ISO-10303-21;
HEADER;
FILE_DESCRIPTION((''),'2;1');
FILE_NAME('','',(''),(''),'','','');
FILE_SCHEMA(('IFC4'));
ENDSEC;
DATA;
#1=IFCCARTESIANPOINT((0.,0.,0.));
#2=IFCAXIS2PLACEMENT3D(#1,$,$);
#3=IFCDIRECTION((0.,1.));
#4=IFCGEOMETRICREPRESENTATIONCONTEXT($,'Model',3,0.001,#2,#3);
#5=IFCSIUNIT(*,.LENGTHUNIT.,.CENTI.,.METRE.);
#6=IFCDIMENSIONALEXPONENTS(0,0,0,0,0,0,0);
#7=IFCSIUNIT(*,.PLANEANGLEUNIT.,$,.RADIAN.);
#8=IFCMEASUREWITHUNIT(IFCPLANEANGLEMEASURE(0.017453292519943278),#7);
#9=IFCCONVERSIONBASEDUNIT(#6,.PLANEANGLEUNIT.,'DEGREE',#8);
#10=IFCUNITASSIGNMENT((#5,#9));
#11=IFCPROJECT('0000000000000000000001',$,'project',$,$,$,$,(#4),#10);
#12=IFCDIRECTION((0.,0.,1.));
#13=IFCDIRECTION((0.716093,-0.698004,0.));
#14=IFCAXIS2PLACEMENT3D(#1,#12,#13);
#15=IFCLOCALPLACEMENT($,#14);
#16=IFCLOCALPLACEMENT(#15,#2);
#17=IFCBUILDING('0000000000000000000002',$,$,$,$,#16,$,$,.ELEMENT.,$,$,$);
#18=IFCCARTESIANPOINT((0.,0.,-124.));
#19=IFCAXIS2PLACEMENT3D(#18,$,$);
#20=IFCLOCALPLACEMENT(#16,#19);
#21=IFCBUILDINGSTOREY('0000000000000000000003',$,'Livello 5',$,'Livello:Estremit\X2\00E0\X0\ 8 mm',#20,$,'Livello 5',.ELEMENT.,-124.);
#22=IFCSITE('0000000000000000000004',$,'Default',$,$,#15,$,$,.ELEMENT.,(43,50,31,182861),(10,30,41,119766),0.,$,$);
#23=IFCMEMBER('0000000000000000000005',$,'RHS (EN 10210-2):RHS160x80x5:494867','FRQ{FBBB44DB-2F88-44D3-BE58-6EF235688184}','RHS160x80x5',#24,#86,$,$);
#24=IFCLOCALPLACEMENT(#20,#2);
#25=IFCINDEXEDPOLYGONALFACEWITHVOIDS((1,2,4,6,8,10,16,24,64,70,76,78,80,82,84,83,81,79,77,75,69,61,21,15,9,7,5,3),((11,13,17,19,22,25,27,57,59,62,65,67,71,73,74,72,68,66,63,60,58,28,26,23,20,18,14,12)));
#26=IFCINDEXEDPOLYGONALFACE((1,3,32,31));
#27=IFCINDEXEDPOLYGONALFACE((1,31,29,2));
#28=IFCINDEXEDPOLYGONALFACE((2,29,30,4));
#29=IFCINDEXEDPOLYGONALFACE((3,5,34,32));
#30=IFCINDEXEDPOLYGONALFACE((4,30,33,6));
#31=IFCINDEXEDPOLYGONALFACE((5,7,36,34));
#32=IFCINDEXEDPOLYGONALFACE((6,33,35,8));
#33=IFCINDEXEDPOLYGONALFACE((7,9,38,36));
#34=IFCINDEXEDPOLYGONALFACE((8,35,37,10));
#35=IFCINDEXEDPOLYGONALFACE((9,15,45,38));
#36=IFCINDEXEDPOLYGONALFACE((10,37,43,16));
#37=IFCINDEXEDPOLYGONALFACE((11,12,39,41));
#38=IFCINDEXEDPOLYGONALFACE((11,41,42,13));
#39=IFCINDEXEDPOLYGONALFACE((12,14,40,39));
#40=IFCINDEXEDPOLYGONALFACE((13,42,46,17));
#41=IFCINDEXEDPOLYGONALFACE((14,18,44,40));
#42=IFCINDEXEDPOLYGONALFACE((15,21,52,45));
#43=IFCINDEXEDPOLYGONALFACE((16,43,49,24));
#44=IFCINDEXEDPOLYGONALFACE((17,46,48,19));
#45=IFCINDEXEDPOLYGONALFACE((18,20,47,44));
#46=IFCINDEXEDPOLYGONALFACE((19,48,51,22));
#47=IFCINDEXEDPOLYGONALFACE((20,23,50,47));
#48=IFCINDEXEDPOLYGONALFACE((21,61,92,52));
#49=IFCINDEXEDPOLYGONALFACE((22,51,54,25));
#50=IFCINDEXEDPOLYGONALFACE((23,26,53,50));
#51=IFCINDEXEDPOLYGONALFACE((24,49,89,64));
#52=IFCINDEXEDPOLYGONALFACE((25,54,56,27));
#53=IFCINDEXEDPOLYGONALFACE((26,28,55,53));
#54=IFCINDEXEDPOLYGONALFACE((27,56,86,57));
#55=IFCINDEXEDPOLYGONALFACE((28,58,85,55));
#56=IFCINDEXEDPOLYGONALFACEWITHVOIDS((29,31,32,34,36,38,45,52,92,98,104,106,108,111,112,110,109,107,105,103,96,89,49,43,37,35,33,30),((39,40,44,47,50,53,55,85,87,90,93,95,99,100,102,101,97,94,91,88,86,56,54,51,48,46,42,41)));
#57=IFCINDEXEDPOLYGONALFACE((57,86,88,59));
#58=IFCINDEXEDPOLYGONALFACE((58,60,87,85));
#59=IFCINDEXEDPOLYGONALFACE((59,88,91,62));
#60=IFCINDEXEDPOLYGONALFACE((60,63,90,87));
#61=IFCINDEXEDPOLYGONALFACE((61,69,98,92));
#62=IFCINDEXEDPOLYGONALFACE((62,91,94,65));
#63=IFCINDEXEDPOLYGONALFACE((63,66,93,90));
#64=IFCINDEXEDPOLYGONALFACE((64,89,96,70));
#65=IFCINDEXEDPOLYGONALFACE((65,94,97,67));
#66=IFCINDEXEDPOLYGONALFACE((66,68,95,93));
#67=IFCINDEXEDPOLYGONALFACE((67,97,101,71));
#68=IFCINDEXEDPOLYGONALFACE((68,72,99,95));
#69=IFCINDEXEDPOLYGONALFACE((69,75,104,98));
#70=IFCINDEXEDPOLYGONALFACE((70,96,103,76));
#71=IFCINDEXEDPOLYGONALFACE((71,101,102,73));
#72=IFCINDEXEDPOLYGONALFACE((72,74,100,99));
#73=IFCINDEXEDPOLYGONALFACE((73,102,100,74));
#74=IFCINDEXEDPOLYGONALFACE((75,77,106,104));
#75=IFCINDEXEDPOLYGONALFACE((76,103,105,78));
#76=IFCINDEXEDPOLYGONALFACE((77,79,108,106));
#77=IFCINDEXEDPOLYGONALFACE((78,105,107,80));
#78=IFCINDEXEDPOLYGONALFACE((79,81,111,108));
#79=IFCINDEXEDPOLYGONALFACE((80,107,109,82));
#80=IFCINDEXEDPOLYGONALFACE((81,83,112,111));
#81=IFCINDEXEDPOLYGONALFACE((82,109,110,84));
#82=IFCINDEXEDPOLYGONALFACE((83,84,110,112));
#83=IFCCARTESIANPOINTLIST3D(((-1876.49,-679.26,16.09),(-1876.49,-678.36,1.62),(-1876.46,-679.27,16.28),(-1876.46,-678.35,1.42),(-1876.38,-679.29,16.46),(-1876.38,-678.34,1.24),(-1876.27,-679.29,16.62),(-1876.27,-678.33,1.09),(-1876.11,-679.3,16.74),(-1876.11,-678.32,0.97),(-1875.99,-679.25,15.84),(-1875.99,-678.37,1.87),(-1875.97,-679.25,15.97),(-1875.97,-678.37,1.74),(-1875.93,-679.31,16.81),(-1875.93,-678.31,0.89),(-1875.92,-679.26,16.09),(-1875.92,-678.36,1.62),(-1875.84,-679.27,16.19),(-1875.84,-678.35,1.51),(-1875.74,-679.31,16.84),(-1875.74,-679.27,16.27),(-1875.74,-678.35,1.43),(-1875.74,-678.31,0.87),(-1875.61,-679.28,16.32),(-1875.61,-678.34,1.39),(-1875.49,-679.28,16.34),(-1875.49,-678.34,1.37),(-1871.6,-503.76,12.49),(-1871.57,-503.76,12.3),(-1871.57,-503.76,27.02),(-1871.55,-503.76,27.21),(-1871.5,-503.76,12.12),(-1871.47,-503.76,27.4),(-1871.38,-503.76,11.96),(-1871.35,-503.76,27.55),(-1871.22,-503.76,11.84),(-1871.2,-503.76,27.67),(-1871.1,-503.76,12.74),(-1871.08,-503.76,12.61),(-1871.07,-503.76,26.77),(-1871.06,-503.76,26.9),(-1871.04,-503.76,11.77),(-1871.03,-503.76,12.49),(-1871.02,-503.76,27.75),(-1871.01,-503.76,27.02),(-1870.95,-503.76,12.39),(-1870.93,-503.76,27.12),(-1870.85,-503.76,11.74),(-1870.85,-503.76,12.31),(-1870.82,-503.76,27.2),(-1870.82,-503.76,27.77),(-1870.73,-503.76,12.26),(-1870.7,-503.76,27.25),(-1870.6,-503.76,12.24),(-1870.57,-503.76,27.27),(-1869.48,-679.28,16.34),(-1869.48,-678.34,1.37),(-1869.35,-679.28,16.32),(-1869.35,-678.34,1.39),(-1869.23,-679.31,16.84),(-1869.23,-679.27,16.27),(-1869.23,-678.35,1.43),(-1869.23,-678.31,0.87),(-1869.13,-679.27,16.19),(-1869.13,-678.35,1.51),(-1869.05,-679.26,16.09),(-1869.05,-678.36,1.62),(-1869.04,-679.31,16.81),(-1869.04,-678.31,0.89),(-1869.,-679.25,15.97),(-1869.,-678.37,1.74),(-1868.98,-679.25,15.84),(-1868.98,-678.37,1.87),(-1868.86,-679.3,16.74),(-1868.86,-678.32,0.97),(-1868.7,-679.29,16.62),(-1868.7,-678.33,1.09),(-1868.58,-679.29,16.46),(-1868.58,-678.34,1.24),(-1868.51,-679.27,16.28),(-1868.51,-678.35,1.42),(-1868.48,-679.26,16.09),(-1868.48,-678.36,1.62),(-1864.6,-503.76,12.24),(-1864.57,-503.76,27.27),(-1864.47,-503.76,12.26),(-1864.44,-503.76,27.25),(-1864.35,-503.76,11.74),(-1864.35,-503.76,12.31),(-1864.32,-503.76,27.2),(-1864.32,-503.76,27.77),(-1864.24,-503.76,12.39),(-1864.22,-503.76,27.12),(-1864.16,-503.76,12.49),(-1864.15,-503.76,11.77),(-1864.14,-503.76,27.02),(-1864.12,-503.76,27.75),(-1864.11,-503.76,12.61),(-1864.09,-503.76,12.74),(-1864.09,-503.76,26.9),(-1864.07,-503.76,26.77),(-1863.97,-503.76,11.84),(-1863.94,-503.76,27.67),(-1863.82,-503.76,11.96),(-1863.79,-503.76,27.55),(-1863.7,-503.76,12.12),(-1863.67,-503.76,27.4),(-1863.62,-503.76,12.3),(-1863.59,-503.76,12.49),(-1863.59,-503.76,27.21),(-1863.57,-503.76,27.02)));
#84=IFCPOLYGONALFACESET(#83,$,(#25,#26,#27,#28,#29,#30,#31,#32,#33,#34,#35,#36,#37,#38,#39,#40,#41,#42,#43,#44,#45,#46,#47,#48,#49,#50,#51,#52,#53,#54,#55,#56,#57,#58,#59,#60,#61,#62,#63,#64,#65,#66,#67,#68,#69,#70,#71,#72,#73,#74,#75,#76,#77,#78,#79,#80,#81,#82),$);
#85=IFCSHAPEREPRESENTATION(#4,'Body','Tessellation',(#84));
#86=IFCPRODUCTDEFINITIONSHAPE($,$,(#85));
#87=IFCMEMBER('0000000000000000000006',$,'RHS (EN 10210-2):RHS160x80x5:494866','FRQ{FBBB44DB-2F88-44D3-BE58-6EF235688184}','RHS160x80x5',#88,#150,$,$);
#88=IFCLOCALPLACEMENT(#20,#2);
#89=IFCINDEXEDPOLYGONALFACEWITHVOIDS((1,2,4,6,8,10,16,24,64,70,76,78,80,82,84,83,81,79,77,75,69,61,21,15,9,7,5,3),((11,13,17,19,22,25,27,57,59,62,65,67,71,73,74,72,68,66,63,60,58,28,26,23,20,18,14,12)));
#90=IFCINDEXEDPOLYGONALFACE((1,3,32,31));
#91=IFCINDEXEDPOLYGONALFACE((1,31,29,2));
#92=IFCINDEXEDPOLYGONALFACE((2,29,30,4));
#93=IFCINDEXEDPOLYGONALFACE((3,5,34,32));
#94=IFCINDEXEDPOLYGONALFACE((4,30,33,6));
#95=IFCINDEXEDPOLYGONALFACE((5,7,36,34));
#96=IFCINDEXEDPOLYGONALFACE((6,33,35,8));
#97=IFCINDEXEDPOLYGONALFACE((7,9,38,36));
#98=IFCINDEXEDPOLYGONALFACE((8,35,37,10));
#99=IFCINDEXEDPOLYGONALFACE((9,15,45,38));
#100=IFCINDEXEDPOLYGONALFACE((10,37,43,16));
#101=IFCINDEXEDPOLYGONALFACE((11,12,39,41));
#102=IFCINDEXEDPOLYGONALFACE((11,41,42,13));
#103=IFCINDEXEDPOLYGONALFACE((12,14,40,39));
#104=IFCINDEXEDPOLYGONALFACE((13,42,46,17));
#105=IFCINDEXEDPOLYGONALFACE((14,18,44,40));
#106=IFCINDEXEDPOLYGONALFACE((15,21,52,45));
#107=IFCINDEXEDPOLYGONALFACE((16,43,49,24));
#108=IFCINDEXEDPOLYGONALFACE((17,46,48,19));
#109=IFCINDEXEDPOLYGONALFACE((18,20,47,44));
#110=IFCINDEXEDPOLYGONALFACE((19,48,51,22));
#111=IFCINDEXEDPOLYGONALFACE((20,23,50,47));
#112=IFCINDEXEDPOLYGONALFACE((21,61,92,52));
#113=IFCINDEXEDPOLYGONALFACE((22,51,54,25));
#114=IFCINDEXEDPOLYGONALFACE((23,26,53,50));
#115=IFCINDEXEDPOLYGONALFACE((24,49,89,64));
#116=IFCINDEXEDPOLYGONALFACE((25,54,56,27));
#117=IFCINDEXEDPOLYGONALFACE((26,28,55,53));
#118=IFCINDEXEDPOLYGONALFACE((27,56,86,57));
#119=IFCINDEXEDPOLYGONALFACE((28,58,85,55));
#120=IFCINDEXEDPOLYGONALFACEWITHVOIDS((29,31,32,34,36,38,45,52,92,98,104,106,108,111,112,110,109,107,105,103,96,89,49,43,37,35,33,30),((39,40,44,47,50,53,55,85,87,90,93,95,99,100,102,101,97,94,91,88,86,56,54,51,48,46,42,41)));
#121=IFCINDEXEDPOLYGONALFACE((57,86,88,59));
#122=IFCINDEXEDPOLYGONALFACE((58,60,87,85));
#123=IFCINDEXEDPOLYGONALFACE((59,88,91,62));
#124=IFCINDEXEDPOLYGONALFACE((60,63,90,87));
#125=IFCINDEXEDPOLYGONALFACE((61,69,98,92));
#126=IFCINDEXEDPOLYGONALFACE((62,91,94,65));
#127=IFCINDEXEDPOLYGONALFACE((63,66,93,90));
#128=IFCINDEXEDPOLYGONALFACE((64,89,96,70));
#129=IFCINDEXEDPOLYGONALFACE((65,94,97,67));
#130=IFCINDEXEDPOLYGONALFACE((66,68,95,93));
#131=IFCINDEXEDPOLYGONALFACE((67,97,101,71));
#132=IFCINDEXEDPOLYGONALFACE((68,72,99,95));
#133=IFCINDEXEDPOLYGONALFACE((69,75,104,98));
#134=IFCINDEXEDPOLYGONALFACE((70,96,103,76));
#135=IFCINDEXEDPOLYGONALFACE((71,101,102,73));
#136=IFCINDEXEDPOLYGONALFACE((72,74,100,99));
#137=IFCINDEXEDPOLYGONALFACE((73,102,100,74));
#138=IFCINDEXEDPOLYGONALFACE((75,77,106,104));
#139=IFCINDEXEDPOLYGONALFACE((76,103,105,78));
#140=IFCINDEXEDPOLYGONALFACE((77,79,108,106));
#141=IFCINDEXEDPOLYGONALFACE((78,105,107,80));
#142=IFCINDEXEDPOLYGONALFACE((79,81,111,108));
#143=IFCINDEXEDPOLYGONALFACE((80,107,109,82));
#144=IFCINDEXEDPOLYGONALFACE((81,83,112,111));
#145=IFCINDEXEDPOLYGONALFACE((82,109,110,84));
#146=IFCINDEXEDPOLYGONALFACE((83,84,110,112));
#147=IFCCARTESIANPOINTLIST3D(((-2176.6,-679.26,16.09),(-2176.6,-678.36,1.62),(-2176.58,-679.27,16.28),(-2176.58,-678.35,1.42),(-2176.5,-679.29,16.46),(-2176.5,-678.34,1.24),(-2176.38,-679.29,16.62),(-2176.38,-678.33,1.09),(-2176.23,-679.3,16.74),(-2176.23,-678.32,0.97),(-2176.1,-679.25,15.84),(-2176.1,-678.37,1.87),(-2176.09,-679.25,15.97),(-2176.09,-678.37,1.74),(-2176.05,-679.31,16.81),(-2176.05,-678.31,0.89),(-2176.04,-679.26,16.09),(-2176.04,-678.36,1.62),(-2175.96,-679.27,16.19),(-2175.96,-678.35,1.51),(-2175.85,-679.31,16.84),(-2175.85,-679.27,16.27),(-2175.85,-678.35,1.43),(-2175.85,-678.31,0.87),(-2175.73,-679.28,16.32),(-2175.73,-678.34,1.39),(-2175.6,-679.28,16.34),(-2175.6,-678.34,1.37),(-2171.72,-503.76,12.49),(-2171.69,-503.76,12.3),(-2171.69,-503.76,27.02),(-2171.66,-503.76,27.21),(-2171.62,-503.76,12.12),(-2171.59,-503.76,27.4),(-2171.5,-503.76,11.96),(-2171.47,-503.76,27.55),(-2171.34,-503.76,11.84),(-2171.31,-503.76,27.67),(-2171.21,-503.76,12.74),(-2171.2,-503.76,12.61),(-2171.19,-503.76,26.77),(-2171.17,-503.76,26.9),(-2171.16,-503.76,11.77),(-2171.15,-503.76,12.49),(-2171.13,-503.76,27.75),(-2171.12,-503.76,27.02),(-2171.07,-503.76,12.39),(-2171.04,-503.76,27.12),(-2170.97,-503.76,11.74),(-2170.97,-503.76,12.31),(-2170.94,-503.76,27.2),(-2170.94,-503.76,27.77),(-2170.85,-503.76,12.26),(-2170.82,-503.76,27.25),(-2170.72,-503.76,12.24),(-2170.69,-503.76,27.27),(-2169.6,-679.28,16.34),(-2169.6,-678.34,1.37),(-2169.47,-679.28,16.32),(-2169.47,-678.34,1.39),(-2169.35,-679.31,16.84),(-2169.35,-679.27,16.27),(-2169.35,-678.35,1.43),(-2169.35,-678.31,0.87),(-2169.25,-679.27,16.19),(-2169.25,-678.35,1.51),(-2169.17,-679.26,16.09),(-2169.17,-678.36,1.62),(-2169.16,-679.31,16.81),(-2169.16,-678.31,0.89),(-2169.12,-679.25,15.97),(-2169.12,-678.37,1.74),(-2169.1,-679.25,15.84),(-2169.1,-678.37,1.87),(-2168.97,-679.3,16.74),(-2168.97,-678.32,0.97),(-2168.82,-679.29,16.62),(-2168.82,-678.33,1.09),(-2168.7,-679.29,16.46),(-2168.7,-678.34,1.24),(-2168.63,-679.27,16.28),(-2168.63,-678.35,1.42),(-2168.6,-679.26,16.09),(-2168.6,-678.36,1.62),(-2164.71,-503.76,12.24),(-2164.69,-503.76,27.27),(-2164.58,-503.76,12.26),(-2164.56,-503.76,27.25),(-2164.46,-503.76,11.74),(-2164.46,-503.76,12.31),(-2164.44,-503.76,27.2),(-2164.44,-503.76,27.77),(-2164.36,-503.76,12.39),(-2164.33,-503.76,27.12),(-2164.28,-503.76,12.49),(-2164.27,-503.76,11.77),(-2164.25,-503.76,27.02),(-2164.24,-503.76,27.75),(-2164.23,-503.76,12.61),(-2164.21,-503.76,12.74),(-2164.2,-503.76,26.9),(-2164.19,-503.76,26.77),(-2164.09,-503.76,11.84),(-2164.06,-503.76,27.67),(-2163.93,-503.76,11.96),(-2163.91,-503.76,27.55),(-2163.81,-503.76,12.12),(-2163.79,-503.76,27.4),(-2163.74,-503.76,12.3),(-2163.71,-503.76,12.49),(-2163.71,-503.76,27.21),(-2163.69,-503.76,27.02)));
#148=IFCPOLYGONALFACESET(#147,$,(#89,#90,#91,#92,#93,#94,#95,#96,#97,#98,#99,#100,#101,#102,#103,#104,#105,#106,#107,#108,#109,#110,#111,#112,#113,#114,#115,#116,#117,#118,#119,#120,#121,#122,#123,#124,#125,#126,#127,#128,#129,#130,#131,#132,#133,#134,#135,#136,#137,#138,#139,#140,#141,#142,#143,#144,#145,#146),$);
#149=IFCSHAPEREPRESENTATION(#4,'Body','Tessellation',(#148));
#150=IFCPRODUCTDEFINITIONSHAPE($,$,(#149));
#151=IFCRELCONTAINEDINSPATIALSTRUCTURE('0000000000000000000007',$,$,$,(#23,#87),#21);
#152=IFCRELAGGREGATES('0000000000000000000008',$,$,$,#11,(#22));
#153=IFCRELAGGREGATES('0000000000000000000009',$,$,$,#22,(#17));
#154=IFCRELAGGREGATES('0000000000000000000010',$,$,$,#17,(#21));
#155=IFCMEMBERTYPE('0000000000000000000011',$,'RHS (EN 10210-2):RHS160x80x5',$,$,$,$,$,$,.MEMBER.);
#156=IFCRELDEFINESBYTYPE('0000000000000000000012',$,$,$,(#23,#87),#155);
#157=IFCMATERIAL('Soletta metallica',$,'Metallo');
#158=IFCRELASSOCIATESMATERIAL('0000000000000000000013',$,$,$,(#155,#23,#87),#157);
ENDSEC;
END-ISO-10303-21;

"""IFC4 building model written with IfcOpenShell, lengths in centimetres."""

from ifc_helpers import new_model, entity, si_unit, converted_unit, direction, frame, origin, origin_2d, place, context, project, spatial, hollow_rectangle, extrude, clip, halfspace, material, type_object, element, save


model = new_model("IFC4")

# Units and contexts
model_context = context("Model", 3, precision=0.001, world=origin(), true_north=direction((0.0, 1.0)))
ifc_project = project(units=[si_unit("LENGTHUNIT", "METRE", prefix="CENTI"), converted_unit("PLANEANGLEUNIT", "DEGREE", entity("IfcPlaneAngleMeasure", 0.017453292519943278), si_unit("PLANEANGLEUNIT", "RADIAN"), dimensions=[0, 0, 0, 0, 0, 0, 0])], contexts=[model_context])

# Site, building, storey
site_placement = place(None, frame((0.0, 0.0, 0.0), z_axis=(0.0, 0.0, 1.0), x_axis=(0.716093, -0.698004, 0.0)))
site = spatial("IfcSite", under=ifc_project, at=site_placement, Name="Default", CompositionType="ELEMENT", RefLatitude=(43, 50, 31, 182861), RefLongitude=(10, 30, 41, 119766), RefElevation=0.0)
building_placement = place(site_placement, origin())
building = spatial("IfcBuilding", under=site, at=building_placement, CompositionType="ELEMENT")
storey_placement = place(building_placement, frame((0.0, 0.0, -124.0)))
storey = spatial("IfcBuildingStorey", under=building, at=storey_placement, Name="Livello 5", ObjectType="Livello:Estremità 8 mm", LongName="Livello 5", CompositionType="ELEMENT", Elevation=-124.0)

# Shared definitions
ifc_material_1 = material(Name="Soletta metallica", Category="Metallo")

# Members
member_type_1 = type_object("IfcMemberType", Name="RHS (EN 10210-2):RHS160x80x5", PredefinedType="MEMBER", material=ifc_material_1)
member_1_placement = place(storey_placement, frame((-1873.57, -717.68, 6.43), z_axis=(-0.027926, -0.997677, -0.062135), x_axis=(0.99961, -0.027872, -0.001736)))
element("IfcMember", 1, at=member_1_placement, inside=storey, type_object=member_type_1, material=ifc_material_1, Name="RHS (EN 10210-2):RHS160x80x5:494867", Description="FRQ{FBBB44DB-2F88-44D3-BE58-6EF235688184}", ObjectType="RHS160x80x5", context=model_context, shape_type="Clipping", body=[
    clip(clip(extrude(hollow_rectangle(XDim=8.0, YDim=16.0, WallThickness=0.5, InnerFilletRadius=0.5, OuterFilletRadius=0.75, at=origin_2d()), origin(), (0.0, 0.0, -1.0), 242.93), halfspace(frame((1866.85, 100.78, -273.06), z_axis=(0.02798, 0.062159, 0.997674), x_axis=(0.999608, -0.00174, -0.027926)), True)), halfspace(frame((1871.88, 69.4, -91.25), z_axis=(-0.027926, 0.000109, -0.99961), x_axis=(-0.999608, 0.00174, 0.027926)), True)),
])
member_2_placement = place(storey_placement, frame((-2173.69, -717.68, 6.43), z_axis=(-0.027926, -0.997677, -0.062135), x_axis=(0.99961, -0.027872, -0.001736)))
element("IfcMember", 2, at=member_2_placement, inside=storey, type_object=member_type_1, material=ifc_material_1, Name="RHS (EN 10210-2):RHS160x80x5:494866", Description="FRQ{FBBB44DB-2F88-44D3-BE58-6EF235688184}", ObjectType="RHS160x80x5", context=model_context, shape_type="Clipping", body=[
    clip(clip(extrude(hollow_rectangle(XDim=8.0, YDim=16.0, WallThickness=0.5, InnerFilletRadius=0.5, OuterFilletRadius=0.75, at=origin_2d()), origin(), (0.0, 0.0, -1.0), 242.93), halfspace(frame((2166.85, 100.26, -281.44), z_axis=(0.02798, 0.062159, 0.997674), x_axis=(0.999608, -0.00174, -0.027926)), True)), halfspace(frame((2171.88, 68.87, -99.63), z_axis=(-0.027926, 0.000109, -0.99961), x_axis=(-0.999608, 0.00174, 0.027926)), True)),
])

save(model, "model.ifc")
